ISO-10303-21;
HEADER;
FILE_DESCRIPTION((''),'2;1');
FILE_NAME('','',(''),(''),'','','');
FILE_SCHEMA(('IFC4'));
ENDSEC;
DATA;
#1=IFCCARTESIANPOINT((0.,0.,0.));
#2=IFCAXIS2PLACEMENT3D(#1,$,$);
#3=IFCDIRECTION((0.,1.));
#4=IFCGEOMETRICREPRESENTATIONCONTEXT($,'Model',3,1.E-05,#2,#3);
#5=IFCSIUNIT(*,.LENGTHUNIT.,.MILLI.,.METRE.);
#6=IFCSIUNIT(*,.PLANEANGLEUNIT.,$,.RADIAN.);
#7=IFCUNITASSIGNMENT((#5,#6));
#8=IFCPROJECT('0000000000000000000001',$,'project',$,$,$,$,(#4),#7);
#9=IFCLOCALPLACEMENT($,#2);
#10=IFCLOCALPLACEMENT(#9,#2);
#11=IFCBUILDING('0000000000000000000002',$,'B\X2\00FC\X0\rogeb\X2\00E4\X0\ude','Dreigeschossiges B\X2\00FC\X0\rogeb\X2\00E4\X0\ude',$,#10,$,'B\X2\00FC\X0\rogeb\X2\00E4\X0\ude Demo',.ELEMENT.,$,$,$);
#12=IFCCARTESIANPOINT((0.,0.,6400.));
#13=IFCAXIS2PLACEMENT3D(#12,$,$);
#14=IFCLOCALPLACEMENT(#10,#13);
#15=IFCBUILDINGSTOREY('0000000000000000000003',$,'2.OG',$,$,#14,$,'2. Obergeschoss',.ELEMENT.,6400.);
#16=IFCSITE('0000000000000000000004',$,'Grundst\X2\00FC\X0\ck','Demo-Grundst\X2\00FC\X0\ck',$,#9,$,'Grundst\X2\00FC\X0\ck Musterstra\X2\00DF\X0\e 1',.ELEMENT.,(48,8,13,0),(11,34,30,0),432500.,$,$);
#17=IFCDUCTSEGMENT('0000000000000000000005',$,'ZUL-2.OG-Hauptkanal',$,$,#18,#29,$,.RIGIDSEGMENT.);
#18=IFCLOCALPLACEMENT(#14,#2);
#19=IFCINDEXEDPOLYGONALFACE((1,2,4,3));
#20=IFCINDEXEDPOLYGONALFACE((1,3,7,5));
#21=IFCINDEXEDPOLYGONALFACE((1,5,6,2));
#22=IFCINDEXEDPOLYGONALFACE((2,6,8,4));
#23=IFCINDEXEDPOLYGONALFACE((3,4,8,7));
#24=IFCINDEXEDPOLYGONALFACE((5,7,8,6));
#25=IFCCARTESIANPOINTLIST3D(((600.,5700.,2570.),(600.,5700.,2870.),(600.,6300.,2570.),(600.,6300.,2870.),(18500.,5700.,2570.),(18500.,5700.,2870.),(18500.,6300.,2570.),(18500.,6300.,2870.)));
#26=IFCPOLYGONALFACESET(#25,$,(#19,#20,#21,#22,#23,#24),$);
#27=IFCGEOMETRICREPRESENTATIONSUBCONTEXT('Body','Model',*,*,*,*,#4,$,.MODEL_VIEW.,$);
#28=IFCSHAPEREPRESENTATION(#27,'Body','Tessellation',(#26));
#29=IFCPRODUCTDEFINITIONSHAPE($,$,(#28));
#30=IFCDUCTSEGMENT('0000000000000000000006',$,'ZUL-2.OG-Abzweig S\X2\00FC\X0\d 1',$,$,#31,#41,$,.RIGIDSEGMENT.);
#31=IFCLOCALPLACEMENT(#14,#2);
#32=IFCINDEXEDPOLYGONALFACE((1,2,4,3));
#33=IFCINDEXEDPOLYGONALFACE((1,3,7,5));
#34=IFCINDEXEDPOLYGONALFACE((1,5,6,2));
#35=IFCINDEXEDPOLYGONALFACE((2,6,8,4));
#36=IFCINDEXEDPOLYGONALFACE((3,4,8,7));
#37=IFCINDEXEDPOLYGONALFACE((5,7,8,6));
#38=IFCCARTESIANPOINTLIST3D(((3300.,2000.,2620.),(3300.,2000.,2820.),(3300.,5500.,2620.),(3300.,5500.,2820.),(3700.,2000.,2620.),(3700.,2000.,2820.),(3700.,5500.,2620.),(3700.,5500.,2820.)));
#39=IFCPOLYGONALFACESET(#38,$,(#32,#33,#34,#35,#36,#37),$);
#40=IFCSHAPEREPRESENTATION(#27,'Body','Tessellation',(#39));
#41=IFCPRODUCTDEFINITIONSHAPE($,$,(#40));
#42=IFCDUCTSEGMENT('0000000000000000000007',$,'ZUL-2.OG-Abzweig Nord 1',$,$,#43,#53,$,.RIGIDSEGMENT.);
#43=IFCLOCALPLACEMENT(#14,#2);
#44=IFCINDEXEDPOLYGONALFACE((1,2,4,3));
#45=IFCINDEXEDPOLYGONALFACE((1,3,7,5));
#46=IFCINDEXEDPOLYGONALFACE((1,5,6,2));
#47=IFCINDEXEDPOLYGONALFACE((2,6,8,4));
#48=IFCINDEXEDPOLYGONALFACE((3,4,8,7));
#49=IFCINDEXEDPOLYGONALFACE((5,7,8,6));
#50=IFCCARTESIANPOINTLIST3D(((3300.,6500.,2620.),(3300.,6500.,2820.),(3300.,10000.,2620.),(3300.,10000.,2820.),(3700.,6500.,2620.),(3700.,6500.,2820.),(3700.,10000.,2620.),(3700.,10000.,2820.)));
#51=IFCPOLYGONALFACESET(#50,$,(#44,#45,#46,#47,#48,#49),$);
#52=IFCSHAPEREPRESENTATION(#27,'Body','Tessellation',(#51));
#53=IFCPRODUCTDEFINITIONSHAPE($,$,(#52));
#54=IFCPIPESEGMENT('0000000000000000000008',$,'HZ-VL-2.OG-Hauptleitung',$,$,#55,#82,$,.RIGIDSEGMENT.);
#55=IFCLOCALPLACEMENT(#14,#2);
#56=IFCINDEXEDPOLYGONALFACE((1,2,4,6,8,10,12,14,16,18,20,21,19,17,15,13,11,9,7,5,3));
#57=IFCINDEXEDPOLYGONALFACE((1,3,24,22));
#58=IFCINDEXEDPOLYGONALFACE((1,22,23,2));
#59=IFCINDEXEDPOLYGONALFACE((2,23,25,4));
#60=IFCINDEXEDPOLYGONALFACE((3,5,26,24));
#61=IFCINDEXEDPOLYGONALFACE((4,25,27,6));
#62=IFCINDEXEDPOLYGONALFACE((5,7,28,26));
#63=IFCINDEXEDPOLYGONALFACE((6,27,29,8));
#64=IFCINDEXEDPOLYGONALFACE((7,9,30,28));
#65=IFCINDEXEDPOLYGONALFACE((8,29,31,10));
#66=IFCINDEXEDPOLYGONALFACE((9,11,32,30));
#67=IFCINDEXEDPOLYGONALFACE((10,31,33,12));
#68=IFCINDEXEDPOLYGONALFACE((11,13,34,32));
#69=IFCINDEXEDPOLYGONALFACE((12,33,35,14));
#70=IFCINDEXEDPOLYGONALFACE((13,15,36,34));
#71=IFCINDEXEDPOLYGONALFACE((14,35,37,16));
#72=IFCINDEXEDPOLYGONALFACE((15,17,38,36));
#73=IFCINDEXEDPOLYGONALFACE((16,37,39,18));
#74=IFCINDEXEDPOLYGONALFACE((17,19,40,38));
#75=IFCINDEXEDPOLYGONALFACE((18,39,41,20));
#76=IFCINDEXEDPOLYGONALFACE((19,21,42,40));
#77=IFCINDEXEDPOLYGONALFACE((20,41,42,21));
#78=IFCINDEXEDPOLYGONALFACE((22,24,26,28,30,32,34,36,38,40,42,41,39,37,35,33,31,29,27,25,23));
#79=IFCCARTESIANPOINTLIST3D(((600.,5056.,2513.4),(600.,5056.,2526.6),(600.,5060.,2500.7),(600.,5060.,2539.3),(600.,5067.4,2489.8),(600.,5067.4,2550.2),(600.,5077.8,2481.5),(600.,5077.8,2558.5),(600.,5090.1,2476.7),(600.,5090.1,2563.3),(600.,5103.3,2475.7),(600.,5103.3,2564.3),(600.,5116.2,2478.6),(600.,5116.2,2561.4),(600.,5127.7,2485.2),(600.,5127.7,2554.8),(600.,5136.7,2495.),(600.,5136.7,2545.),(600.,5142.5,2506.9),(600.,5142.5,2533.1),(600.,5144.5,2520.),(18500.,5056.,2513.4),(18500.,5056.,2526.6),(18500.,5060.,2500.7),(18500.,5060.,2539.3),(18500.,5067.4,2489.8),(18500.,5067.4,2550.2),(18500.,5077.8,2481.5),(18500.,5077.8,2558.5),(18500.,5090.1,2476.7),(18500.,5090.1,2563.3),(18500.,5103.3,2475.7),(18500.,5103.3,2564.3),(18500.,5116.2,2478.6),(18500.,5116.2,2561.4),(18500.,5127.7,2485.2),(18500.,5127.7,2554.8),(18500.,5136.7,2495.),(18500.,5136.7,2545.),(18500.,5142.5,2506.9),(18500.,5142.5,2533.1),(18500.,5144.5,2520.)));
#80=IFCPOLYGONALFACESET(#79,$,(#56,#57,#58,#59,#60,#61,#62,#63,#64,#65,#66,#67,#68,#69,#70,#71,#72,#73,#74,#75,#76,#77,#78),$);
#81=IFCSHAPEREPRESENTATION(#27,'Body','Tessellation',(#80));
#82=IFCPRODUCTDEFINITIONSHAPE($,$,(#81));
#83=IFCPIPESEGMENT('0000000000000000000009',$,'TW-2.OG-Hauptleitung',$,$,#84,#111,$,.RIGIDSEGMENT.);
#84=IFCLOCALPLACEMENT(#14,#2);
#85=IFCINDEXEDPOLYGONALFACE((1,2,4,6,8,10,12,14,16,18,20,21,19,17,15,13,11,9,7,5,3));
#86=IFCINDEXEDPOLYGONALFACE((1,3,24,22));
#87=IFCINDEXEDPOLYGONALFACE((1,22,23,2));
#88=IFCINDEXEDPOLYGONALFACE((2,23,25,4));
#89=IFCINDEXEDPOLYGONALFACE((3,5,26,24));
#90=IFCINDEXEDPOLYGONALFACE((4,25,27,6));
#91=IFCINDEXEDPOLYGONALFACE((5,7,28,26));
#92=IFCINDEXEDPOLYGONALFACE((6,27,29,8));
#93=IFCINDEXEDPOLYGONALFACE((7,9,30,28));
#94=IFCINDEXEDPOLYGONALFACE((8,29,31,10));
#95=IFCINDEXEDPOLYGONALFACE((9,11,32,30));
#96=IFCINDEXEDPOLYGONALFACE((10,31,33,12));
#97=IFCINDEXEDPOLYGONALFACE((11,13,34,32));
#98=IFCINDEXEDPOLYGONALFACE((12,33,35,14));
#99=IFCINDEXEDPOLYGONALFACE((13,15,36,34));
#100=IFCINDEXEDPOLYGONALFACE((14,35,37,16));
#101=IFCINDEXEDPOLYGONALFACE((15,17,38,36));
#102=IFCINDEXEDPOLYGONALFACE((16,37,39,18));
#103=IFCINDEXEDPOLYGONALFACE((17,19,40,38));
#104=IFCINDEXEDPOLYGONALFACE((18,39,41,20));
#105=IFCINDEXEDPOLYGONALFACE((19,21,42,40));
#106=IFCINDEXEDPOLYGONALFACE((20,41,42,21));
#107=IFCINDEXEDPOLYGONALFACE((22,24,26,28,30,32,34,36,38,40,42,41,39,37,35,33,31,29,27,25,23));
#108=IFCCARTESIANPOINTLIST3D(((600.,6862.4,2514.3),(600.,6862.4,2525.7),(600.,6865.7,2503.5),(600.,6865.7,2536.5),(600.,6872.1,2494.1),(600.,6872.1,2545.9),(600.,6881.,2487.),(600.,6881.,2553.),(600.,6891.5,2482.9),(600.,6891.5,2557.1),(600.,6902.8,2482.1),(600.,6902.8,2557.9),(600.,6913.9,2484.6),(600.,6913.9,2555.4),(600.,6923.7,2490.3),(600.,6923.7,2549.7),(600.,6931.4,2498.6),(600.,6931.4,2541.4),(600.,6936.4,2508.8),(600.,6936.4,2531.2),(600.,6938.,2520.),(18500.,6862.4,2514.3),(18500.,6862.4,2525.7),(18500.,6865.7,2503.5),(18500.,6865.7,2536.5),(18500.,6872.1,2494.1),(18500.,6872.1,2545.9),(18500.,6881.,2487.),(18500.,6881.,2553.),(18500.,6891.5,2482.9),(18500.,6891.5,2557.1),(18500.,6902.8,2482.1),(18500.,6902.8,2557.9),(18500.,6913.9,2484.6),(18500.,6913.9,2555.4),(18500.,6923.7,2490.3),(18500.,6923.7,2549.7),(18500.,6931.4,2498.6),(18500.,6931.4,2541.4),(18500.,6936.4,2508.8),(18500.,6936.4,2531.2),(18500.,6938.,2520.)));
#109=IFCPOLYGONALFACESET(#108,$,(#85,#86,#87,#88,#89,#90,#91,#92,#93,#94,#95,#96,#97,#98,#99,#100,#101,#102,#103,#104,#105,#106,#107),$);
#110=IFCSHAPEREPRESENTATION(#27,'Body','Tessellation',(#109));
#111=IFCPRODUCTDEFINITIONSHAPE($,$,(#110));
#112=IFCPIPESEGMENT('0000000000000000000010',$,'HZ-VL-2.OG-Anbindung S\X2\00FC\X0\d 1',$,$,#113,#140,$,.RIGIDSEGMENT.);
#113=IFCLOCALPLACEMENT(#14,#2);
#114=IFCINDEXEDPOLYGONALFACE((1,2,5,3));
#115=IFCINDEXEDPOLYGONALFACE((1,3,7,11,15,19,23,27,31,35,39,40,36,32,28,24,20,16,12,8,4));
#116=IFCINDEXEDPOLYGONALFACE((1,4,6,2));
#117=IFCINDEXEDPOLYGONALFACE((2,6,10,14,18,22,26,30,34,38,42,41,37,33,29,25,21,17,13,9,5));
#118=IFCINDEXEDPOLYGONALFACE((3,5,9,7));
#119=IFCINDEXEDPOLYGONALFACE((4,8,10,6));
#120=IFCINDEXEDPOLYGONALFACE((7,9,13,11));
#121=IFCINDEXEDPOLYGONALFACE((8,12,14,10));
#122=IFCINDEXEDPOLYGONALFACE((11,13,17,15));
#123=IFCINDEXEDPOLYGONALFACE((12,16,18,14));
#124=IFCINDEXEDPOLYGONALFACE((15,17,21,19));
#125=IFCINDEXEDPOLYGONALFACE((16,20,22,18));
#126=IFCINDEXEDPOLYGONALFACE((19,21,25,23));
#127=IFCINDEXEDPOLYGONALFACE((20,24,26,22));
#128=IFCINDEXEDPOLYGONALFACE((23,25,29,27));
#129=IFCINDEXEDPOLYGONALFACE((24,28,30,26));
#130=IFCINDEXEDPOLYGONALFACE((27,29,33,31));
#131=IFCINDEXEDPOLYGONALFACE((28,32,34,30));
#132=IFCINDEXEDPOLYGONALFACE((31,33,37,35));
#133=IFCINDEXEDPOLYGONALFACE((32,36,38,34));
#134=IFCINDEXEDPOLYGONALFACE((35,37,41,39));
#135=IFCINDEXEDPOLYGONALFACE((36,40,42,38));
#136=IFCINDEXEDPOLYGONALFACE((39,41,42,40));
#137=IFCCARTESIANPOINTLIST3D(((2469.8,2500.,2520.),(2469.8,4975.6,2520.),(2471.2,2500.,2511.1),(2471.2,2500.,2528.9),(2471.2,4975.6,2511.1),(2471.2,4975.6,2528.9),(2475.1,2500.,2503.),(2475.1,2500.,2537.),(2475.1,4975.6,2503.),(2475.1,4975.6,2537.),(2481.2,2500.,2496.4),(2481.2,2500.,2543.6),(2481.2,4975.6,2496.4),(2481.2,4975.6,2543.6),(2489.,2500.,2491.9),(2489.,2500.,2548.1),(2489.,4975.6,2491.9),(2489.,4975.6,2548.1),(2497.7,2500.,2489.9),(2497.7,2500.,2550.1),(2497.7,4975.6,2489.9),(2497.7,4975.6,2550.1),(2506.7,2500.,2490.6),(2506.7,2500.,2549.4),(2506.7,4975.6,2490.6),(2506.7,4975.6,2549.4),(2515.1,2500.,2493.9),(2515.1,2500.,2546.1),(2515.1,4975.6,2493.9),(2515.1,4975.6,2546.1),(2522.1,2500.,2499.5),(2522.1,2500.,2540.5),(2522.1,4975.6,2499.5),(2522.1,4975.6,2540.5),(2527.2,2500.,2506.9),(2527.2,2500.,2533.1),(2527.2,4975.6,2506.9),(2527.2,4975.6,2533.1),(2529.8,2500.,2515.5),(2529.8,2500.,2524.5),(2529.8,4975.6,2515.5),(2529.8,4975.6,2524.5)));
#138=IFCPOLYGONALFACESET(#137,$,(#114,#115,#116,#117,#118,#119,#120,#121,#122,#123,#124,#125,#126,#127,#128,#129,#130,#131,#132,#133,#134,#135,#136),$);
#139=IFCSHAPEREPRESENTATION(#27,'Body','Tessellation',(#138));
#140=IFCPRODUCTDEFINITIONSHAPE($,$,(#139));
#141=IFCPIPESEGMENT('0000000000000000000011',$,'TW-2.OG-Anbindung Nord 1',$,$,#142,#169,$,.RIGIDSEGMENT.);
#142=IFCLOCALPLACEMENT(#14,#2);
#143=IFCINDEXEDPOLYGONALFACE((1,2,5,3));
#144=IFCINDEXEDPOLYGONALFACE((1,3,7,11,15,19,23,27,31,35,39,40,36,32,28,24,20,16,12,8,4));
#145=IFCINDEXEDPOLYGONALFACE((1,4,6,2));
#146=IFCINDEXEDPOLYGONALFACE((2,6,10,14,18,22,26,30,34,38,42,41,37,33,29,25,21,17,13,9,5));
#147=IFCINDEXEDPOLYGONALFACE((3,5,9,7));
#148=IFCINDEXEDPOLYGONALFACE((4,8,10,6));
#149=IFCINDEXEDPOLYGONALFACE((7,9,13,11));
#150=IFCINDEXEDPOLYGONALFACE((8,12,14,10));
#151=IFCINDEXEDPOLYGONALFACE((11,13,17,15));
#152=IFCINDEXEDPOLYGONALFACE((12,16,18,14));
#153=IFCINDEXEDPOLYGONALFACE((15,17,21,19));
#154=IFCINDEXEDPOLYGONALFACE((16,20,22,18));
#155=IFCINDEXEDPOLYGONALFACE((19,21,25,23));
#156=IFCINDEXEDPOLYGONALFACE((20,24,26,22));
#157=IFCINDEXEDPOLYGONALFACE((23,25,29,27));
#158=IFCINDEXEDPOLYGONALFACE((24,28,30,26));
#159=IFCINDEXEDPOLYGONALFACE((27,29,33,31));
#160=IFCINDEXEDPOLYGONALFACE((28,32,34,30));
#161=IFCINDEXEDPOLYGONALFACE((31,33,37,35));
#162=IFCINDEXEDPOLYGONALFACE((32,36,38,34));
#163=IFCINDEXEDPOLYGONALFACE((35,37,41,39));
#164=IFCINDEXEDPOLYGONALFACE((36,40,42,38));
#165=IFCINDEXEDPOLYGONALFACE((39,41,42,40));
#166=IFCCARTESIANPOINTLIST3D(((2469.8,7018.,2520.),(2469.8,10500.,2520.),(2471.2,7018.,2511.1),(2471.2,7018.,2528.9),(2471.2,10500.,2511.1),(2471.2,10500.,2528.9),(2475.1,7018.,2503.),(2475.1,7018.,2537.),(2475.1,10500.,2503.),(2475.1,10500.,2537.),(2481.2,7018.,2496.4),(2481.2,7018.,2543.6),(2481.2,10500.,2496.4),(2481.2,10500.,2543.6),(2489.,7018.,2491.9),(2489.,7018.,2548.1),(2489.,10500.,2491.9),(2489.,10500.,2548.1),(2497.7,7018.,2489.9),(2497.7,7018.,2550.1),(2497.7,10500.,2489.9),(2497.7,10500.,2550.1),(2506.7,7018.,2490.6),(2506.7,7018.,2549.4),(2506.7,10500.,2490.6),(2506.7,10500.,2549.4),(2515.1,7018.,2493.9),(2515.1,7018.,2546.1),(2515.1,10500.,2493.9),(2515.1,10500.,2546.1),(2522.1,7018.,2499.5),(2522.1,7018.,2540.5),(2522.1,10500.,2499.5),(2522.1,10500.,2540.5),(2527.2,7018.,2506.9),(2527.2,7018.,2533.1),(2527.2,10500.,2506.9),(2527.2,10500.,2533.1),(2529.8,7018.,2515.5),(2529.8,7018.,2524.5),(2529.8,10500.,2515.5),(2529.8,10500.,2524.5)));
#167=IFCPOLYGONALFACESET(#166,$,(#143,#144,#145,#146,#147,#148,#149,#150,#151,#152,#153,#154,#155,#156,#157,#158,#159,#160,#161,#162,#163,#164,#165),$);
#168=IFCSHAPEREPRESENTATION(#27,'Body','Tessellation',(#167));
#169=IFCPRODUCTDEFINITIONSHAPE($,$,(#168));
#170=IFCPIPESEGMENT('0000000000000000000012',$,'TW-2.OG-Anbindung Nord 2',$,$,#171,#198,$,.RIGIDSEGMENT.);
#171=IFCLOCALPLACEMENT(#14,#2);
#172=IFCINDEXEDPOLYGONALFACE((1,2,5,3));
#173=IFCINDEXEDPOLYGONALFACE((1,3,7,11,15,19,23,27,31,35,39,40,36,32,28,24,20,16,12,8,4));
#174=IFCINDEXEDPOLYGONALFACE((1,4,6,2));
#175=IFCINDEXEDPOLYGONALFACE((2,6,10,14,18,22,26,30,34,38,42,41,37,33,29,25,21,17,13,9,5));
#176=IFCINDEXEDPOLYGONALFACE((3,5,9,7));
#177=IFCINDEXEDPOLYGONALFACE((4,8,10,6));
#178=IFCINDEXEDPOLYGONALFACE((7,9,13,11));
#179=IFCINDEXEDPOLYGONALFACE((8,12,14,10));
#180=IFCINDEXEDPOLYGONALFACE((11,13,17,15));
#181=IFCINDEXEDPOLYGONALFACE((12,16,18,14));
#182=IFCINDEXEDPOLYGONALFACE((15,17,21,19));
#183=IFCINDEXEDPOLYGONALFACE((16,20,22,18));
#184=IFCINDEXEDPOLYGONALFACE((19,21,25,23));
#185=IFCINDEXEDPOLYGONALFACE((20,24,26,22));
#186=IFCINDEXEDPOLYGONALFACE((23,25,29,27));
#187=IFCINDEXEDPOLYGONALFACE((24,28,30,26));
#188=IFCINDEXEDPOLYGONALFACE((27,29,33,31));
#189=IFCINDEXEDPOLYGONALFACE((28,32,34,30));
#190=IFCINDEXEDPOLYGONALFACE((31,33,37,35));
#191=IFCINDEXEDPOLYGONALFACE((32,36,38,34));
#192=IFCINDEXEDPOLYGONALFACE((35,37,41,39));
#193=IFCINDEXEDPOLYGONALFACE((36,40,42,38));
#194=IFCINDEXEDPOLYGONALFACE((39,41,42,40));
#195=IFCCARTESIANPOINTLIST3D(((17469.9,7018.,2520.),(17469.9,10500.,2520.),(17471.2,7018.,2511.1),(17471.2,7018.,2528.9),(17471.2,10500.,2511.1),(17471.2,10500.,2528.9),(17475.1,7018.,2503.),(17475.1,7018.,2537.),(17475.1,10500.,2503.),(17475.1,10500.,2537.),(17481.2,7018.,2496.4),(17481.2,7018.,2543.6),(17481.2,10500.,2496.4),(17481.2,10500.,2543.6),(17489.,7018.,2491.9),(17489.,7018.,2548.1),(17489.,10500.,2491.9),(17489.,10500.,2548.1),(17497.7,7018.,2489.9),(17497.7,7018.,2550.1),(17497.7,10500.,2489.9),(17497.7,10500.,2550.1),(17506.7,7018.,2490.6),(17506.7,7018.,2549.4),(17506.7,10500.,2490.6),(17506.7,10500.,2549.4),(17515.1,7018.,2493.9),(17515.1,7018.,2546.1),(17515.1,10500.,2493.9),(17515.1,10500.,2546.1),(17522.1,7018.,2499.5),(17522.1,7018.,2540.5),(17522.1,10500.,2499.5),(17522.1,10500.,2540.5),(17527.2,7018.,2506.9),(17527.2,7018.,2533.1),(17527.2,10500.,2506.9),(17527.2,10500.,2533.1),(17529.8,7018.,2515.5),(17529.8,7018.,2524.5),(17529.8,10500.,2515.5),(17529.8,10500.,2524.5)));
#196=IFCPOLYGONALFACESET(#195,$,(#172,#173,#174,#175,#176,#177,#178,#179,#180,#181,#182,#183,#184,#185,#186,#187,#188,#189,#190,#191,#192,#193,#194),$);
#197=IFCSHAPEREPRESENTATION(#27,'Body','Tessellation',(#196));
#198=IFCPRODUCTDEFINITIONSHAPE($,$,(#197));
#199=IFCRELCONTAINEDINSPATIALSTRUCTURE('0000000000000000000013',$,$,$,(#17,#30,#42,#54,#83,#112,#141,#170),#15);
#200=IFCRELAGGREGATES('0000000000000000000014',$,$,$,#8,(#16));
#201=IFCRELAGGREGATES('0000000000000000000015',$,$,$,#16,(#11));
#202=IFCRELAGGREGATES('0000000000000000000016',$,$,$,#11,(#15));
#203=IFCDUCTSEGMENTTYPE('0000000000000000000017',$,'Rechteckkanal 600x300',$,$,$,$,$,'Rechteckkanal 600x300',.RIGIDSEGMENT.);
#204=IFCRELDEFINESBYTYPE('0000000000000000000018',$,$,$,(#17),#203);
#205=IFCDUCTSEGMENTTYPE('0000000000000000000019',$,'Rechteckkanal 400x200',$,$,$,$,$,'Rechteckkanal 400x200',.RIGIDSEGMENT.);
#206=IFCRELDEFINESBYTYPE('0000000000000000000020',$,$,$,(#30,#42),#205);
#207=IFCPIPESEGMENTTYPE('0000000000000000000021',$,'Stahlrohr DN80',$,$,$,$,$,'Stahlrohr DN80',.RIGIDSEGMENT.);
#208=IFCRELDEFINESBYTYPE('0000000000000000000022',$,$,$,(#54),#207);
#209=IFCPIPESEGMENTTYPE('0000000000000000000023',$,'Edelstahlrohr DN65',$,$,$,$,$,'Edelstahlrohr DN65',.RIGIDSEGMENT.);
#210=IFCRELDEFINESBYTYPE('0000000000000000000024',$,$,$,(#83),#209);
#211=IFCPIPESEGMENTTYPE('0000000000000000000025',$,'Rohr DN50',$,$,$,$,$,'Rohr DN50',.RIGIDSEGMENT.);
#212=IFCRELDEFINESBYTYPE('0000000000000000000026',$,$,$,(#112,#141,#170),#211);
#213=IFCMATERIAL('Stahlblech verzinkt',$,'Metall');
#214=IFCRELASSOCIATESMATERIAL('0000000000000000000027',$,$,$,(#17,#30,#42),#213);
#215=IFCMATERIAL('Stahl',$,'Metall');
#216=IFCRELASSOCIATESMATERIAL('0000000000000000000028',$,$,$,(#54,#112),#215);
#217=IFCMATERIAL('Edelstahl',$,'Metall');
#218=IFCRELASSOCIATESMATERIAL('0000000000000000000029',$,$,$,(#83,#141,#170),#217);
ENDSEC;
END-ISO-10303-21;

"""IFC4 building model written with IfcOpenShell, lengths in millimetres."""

from ifc_helpers import new_model, si_unit, direction, frame, origin, origin_2d, place, context, subcontext, project, spatial, rectangle, circle, extrude, material, type_object, element, save


model = new_model("IFC4")

# Units and contexts
model_context = context("Model", 3, precision=1e-05, world=origin(), true_north=direction((0.0, 1.0)))
body_context = subcontext(model_context, "Body", "Model", "MODEL_VIEW")
ifc_project = project(units=[si_unit("LENGTHUNIT", "METRE", prefix="MILLI"), si_unit("PLANEANGLEUNIT", "RADIAN")], contexts=[model_context])

# Site, building, storey
site_placement = place(None, origin())
site = spatial("IfcSite", under=ifc_project, at=site_placement, Name="Grundstück", Description="Demo-Grundstück", LongName="Grundstück Musterstraße 1", CompositionType="ELEMENT", RefLatitude=(48, 8, 13, 0), RefLongitude=(11, 34, 30, 0), RefElevation=432500.0)
building_placement = place(site_placement, origin())
building = spatial("IfcBuilding", under=site, at=building_placement, Name="Bürogebäude", Description="Dreigeschossiges Bürogebäude", LongName="Bürogebäude Demo", CompositionType="ELEMENT")
storey_placement = place(building_placement, frame((0.0, 0.0, 6400.0)))
storey = spatial("IfcBuildingStorey", under=building, at=storey_placement, Name="2.OG", LongName="2. Obergeschoss", CompositionType="ELEMENT", Elevation=6400.0)

# Duct segments
ifc_material_1 = material(Name="Stahlblech verzinkt", Category="Metall")
duct_segment_type_1 = type_object("IfcDuctSegmentType", Name="Rechteckkanal 600x300", ElementType="Rechteckkanal 600x300", PredefinedType="RIGIDSEGMENT")
duct_segment_placement = place(storey_placement, frame((600.0, 6000.0, 2720.0)))
element("IfcDuctSegment", 1, at=duct_segment_placement, inside=storey, type_object=duct_segment_type_1, material=ifc_material_1, Name="ZUL-2.OG-Hauptkanal", PredefinedType="RIGIDSEGMENT", context=body_context, shape_type="SweptSolid", body=[
    extrude(rectangle(XDim=600.0, YDim=300.0, at=origin_2d()), frame((0.0, 0.0, 0.0), z_axis=(1.0, 0.0, 0.0), x_axis=(0.0, 1.0, 0.0)), (0.0, 0.0, 1.0), 17900.0),
])
duct_segment_type_2 = type_object("IfcDuctSegmentType", Name="Rechteckkanal 400x200", ElementType="Rechteckkanal 400x200", PredefinedType="RIGIDSEGMENT")
for number, where, name in (
    (2, (3500.0, 2000.0, 2720.0), "ZUL-2.OG-Abzweig Süd 1"),
    (3, (3500.0, 6500.0, 2720.0), "ZUL-2.OG-Abzweig Nord 1"),
):
    element("IfcDuctSegment", number, at=place(storey_placement, frame(where)), inside=storey, type_object=duct_segment_type_2, material=ifc_material_1, Name=name, PredefinedType="RIGIDSEGMENT", context=body_context, shape_type="SweptSolid", body=[
        extrude(rectangle(XDim=400.0, YDim=200.0, at=origin_2d()), frame((0.0, 0.0, 0.0), z_axis=(0.0, 1.0, 0.0), x_axis=(-1.0, 0.0, 0.0)), (0.0, 0.0, 1.0), 3500.0),
    ])

# Pipe segments
ifc_material_2 = material(Name="Stahl", Category="Metall")
pipe_segment_type_1 = type_object("IfcPipeSegmentType", Name="Stahlrohr DN80", ElementType="Stahlrohr DN80", PredefinedType="RIGIDSEGMENT")
pipe_segment_1_placement = place(storey_placement, frame((600.0, 5100.0, 2520.0)))
element("IfcPipeSegment", 4, at=pipe_segment_1_placement, inside=storey, type_object=pipe_segment_type_1, material=ifc_material_2, Name="HZ-VL-2.OG-Hauptleitung", PredefinedType="RIGIDSEGMENT", context=body_context, shape_type="SweptSolid", body=[
    extrude(circle(Radius=44.5, at=origin_2d()), frame((0.0, 0.0, 0.0), z_axis=(1.0, 0.0, 0.0), x_axis=(0.0, 1.0, 0.0)), (0.0, 0.0, 1.0), 17900.0),
])
ifc_material_3 = material(Name="Edelstahl", Category="Metall")
pipe_segment_type_2 = type_object("IfcPipeSegmentType", Name="Edelstahlrohr DN65", ElementType="Edelstahlrohr DN65", PredefinedType="RIGIDSEGMENT")
pipe_segment_2_placement = place(storey_placement, frame((600.0, 6900.0, 2520.0)))
element("IfcPipeSegment", 5, at=pipe_segment_2_placement, inside=storey, type_object=pipe_segment_type_2, material=ifc_material_3, Name="TW-2.OG-Hauptleitung", PredefinedType="RIGIDSEGMENT", context=body_context, shape_type="SweptSolid", body=[
    extrude(circle(Radius=38.0, at=origin_2d()), frame((0.0, 0.0, 0.0), z_axis=(1.0, 0.0, 0.0), x_axis=(0.0, 1.0, 0.0)), (0.0, 0.0, 1.0), 17900.0),
])
pipe_segment_type_3 = type_object("IfcPipeSegmentType", Name="Rohr DN50", ElementType="Rohr DN50", PredefinedType="RIGIDSEGMENT")
pipe_segment_3_placement = place(storey_placement, frame((2500.0, 2500.0, 2520.0)))
element("IfcPipeSegment", 6, at=pipe_segment_3_placement, inside=storey, type_object=pipe_segment_type_3, material=ifc_material_2, Name="HZ-VL-2.OG-Anbindung Süd 1", PredefinedType="RIGIDSEGMENT", context=body_context, shape_type="SweptSolid", body=[
    extrude(circle(Radius=30.1, at=origin_2d()), frame((0.0, 0.0, 0.0), z_axis=(0.0, 1.0, 0.0), x_axis=(-1.0, 0.0, 0.0)), (0.0, 0.0, 1.0), 2475.6),
])
for number, where, name in (
    (7, (2500.0, 7018.1, 2520.0), "TW-2.OG-Anbindung Nord 1"),
    (8, (17500.0, 7018.1, 2520.0), "TW-2.OG-Anbindung Nord 2"),
):
    element("IfcPipeSegment", number, at=place(storey_placement, frame(where)), inside=storey, type_object=pipe_segment_type_3, material=ifc_material_3, Name=name, PredefinedType="RIGIDSEGMENT", context=body_context, shape_type="SweptSolid", body=[
        extrude(circle(Radius=30.1, at=origin_2d()), frame((0.0, 0.0, 0.0), z_axis=(0.0, 1.0, 0.0), x_axis=(-1.0, 0.0, 0.0)), (0.0, 0.0, 1.0), 3481.9),
    ])

save(model, "model.ifc")
